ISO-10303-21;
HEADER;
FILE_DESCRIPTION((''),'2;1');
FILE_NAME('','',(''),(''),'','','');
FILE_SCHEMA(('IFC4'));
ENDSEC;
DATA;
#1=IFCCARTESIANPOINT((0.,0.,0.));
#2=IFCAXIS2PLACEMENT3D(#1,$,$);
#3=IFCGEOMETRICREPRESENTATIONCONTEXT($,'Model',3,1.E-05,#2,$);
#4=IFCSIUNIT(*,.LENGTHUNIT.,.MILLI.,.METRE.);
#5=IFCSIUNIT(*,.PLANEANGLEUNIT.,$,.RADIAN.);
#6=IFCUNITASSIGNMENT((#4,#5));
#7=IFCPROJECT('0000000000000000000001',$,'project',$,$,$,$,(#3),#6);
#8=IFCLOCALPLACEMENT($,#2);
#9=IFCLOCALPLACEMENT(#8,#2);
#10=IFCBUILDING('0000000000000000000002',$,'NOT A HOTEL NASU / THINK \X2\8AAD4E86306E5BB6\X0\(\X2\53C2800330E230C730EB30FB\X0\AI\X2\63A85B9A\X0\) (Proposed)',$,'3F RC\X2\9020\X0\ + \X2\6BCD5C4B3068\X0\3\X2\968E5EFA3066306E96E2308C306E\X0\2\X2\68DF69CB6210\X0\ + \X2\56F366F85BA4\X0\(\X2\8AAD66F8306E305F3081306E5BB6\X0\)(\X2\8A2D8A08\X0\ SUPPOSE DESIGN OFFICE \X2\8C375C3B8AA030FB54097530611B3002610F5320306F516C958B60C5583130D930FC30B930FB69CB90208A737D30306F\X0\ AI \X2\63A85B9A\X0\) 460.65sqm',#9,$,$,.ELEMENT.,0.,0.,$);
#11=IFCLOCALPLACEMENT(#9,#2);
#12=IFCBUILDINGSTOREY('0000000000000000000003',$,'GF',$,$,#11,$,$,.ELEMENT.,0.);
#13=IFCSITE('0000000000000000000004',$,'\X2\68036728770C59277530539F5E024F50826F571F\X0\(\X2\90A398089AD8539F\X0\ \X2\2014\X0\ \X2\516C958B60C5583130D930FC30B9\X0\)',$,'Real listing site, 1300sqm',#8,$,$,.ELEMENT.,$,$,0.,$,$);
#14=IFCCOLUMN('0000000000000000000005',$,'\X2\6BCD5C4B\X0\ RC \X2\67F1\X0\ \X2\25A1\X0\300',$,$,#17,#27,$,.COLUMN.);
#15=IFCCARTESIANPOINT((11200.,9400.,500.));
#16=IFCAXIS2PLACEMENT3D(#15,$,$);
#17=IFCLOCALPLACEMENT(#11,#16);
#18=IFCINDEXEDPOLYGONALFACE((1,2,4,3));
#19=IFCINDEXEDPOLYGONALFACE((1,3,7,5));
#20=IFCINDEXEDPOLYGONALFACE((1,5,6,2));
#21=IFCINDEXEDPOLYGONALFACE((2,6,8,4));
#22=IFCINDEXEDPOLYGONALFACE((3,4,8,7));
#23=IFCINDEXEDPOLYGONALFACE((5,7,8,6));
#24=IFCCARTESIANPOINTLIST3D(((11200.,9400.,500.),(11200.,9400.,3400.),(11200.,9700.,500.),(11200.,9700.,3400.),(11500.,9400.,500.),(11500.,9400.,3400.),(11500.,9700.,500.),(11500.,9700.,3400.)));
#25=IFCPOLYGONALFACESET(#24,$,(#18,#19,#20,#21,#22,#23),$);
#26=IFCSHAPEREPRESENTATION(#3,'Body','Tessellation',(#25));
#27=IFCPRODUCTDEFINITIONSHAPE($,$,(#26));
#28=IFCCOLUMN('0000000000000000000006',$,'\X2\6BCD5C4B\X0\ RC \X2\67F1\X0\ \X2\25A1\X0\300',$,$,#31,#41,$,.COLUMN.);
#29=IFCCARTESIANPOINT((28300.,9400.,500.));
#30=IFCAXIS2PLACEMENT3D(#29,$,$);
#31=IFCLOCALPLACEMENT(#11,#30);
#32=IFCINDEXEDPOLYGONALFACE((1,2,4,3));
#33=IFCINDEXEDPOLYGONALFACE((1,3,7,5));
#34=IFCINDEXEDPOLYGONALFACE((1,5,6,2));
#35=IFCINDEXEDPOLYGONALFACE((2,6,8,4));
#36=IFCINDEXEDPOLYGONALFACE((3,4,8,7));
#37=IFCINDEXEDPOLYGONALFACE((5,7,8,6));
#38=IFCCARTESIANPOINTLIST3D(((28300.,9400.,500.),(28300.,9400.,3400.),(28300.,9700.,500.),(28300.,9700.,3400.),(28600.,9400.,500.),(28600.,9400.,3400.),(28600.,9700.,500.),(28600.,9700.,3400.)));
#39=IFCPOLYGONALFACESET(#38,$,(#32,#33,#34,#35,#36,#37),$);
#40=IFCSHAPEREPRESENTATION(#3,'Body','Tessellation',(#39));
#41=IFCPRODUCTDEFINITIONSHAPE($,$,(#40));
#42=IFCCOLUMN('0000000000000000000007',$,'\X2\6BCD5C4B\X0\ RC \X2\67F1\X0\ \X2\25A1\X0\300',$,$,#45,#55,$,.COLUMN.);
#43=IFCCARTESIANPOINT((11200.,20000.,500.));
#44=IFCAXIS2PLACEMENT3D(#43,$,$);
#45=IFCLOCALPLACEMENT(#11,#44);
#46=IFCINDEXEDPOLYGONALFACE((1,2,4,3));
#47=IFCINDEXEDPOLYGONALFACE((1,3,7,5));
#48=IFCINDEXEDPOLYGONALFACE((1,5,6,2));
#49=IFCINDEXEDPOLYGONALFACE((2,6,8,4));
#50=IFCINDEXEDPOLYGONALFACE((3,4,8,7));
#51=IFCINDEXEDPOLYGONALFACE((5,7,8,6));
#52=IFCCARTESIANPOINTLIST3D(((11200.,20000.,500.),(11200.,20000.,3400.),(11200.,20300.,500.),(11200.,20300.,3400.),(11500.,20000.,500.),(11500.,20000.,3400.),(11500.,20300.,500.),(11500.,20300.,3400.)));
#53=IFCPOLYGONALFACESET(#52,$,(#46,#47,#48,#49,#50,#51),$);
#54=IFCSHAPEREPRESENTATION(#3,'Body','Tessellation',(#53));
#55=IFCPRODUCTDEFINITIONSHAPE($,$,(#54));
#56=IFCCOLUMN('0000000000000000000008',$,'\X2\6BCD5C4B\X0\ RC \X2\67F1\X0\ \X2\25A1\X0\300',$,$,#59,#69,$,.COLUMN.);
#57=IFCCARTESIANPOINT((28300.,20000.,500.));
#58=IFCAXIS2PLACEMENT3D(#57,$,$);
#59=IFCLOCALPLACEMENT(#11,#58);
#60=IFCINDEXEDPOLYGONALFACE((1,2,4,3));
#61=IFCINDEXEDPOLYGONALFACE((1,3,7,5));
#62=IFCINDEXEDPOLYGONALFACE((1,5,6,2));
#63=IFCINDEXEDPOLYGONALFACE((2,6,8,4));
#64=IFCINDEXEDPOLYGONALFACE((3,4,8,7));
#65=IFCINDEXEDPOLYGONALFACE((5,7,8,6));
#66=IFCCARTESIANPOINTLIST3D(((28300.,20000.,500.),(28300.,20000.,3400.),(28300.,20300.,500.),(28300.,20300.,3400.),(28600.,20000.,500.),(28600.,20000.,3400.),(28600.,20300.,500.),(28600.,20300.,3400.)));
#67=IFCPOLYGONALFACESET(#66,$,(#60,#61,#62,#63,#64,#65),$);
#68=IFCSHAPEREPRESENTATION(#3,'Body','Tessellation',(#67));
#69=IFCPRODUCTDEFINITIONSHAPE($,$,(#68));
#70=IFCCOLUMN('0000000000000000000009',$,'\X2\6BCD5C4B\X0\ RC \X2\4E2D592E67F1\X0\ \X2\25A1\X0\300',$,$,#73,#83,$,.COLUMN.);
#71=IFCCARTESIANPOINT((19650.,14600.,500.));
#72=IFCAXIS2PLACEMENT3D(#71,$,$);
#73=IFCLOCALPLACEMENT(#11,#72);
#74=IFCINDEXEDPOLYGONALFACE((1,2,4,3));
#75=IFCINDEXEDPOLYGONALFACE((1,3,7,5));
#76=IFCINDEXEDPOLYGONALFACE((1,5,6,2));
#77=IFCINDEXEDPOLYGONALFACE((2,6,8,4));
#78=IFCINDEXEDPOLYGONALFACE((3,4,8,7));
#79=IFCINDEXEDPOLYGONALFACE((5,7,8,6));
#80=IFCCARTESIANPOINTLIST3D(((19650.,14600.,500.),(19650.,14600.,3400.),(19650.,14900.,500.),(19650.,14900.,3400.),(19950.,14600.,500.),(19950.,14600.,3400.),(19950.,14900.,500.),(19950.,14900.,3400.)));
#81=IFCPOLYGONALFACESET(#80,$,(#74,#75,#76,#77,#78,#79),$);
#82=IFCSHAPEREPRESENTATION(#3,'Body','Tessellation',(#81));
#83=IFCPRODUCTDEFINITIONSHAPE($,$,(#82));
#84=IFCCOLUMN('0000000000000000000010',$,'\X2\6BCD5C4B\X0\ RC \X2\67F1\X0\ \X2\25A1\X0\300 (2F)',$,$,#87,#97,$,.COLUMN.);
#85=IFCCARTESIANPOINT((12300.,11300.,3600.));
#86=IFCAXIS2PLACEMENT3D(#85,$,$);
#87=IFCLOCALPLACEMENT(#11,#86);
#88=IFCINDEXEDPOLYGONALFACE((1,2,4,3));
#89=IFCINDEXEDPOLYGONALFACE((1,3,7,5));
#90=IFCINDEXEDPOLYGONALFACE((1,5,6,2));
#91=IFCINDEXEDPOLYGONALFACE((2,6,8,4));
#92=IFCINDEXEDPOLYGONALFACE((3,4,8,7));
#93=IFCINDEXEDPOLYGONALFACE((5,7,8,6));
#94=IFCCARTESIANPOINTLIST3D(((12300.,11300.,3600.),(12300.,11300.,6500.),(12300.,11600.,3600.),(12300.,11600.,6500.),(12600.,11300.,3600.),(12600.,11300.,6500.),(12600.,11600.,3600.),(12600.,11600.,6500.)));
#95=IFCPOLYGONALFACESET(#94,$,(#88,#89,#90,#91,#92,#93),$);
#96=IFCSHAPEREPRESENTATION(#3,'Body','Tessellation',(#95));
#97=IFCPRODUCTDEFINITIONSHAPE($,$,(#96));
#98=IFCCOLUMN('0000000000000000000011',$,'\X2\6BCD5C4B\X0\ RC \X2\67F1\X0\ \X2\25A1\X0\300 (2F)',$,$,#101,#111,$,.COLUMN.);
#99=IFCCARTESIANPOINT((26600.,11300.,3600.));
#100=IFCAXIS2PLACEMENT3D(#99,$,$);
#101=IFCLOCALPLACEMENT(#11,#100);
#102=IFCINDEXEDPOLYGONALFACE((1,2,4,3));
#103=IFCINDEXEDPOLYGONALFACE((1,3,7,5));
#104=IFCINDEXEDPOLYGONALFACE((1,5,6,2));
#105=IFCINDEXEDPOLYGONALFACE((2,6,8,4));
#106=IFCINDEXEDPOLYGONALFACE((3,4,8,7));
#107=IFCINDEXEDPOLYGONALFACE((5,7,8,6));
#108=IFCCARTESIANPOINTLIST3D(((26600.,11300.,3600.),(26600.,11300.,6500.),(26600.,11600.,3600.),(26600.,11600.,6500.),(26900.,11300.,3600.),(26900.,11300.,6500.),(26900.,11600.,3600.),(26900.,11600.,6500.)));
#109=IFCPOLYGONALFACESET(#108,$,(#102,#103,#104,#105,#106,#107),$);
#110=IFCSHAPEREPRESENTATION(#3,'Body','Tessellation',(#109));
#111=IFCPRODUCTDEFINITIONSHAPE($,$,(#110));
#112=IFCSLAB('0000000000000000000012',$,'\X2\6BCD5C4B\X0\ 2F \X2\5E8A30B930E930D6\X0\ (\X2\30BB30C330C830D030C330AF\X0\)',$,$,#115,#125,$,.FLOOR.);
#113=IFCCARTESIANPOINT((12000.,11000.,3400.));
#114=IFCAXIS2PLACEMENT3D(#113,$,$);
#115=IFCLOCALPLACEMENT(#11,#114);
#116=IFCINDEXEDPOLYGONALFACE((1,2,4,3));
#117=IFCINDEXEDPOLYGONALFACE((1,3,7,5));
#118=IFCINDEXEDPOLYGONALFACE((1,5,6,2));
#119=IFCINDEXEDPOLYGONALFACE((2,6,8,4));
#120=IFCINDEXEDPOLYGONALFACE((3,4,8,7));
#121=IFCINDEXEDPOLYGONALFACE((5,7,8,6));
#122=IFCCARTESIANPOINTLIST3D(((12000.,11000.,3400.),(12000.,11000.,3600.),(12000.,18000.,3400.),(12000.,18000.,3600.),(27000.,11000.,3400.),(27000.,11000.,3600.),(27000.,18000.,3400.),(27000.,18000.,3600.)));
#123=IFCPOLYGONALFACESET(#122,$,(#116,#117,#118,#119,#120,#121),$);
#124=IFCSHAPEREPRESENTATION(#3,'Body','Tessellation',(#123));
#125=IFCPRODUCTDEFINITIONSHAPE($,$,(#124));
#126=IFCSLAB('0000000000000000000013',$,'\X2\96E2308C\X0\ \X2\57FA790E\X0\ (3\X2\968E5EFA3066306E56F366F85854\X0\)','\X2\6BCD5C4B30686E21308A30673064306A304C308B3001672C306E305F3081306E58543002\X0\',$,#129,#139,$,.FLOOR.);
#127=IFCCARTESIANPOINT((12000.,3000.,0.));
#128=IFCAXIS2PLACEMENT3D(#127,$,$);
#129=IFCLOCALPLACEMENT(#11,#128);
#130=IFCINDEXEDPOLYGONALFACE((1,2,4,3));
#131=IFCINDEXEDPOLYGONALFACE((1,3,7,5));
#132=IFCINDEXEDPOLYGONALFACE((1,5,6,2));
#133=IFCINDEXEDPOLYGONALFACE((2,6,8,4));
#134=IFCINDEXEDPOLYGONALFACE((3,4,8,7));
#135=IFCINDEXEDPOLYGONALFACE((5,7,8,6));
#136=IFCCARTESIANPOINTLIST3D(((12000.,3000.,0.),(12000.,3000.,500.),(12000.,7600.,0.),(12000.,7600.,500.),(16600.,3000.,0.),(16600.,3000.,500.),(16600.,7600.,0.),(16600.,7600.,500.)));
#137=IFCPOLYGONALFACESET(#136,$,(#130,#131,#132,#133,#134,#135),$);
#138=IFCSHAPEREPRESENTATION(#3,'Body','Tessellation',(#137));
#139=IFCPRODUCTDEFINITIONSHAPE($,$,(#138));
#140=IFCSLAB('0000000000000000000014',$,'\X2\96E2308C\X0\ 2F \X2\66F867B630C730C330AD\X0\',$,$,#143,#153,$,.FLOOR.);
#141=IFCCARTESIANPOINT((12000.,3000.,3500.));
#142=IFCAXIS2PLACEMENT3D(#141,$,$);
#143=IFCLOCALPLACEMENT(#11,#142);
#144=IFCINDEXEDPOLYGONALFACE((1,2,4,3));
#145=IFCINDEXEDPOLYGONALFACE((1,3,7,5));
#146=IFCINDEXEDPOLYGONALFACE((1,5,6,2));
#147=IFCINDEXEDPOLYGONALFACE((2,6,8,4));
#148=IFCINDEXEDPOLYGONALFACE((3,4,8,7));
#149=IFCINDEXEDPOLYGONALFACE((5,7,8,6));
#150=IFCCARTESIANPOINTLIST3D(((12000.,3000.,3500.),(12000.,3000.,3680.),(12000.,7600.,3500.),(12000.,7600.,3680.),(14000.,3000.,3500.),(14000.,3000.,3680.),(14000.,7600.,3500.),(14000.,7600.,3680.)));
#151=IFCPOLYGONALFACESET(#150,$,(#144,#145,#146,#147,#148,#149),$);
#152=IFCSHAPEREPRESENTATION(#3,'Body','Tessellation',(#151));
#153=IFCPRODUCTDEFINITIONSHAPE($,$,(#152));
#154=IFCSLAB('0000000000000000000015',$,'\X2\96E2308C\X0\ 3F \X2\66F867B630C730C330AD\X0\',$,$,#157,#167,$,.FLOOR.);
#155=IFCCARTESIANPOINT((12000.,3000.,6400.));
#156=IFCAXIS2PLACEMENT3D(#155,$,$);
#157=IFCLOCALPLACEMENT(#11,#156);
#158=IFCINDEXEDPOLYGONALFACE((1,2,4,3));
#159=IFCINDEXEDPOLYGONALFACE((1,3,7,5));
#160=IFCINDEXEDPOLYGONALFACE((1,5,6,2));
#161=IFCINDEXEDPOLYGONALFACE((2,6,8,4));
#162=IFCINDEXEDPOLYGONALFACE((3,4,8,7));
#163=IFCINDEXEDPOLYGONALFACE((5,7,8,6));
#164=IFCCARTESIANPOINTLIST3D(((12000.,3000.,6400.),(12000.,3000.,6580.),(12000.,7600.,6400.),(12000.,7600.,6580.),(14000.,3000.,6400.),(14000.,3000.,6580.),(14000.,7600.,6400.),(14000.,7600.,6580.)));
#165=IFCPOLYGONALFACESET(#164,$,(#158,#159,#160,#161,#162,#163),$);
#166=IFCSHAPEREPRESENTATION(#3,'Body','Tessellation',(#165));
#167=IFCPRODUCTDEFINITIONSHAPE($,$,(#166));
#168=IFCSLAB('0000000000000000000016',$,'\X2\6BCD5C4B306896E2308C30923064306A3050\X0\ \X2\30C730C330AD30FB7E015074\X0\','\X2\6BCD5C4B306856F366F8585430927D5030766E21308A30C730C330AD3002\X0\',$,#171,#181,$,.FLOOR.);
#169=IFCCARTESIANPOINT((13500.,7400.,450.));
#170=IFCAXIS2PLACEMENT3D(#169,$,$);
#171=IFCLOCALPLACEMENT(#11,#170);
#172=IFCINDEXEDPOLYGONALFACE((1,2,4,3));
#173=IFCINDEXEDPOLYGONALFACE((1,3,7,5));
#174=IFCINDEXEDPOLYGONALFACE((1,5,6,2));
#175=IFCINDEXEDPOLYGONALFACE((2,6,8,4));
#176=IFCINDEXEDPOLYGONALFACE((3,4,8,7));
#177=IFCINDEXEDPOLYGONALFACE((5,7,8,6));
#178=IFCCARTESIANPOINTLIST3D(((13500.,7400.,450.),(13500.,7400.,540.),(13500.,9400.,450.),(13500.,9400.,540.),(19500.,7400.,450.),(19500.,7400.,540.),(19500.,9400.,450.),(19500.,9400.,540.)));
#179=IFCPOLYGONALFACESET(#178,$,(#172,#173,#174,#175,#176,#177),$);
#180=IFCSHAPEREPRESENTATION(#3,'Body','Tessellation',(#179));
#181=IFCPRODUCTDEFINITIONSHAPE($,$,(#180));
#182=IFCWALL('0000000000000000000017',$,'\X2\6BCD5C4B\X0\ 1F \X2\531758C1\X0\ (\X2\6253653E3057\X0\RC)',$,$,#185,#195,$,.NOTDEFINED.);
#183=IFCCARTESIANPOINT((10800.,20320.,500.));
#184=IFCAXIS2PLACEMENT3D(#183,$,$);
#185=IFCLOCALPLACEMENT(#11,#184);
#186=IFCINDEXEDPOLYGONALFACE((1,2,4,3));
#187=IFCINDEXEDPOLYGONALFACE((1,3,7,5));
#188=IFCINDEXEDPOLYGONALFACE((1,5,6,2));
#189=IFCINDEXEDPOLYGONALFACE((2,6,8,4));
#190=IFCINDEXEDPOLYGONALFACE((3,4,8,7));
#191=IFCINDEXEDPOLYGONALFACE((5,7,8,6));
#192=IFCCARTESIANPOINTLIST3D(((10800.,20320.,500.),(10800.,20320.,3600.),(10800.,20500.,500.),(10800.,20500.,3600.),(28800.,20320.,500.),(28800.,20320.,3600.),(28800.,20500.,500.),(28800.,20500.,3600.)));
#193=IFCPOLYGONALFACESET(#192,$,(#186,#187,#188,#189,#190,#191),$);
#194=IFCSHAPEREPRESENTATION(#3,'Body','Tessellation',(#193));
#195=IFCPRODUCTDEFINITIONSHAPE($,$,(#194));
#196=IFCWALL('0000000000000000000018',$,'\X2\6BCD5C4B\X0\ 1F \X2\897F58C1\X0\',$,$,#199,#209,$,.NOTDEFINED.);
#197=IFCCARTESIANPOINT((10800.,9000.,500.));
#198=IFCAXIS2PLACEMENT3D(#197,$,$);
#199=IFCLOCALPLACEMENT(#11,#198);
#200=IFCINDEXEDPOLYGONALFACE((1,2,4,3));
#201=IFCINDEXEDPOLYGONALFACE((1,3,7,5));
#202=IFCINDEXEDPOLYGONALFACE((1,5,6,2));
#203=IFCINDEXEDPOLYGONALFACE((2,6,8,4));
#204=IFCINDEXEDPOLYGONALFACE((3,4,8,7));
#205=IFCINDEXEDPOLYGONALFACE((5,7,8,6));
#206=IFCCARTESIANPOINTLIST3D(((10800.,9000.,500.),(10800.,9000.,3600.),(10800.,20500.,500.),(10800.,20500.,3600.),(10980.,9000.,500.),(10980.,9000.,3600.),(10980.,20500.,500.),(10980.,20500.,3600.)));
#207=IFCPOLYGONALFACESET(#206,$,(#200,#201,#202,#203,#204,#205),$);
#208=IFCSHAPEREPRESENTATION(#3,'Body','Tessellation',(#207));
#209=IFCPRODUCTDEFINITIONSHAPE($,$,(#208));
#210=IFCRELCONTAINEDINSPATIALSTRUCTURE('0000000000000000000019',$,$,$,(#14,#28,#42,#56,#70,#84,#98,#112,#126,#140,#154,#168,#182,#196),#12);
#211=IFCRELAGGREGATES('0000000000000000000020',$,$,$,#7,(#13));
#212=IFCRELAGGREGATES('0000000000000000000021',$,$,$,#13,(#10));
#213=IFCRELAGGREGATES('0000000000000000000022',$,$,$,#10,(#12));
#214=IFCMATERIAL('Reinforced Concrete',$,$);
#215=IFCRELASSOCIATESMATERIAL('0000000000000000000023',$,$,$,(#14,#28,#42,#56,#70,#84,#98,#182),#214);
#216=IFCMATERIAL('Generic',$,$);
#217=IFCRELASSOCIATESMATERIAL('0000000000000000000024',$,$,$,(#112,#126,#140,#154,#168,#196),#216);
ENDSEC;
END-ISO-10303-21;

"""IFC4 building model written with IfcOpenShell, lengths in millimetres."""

from ifc_helpers import new_model, si_unit, frame, frame_2d, origin, place, context, project, spatial, rectangle, extrude, material, element, save


model = new_model("IFC4")

# Units and contexts
model_context = context("Model", 3, precision=1e-05, world=origin())
ifc_project = project(units=[si_unit("LENGTHUNIT", "METRE", prefix="MILLI"), si_unit("PLANEANGLEUNIT", "RADIAN")], contexts=[model_context])

# Site, building, storey
site_placement = place(None, origin())
site = spatial("IfcSite", under=ifc_project, at=site_placement, Name="栃木県大田原市佐良土(那須高原 — 公開情報ベース)", ObjectType="Real listing site, 1300sqm", CompositionType="ELEMENT", RefElevation=0.0)
building_placement = place(site_placement, origin())
building = spatial("IfcBuilding", under=site, at=building_placement, Name="NOT A HOTEL NASU / THINK 読了の家(参考モデル・AI推定) (Proposed)", ObjectType="3F RC造 + 母屋と3階建ての離れの2棟構成 + 図書室(読書のための家)(設計 SUPPOSE DESIGN OFFICE 谷尻誠・吉田愛。意匠は公開情報ベース・構造詳細は AI 推定) 460.65sqm", CompositionType="ELEMENT", ElevationOfRefHeight=0.0, ElevationOfTerrain=0.0)
storey_placement = place(building_placement, origin())
storey = spatial("IfcBuildingStorey", under=building, at=storey_placement, Name="GF", CompositionType="ELEMENT", Elevation=0.0)

# Columns
ifc_material_1 = material(Name="Reinforced Concrete")
column_1_placement = place(storey_placement, frame((11200.0, 9400.0, 500.0)))
element("IfcColumn", 1, at=column_1_placement, inside=storey, material=ifc_material_1, Name="母屋 RC 柱 □300", PredefinedType="COLUMN", context=model_context, shape_type="SweptSolid", body=[
    extrude(rectangle(XDim=300.0, YDim=300.0, at=frame_2d((150.0, 150.0))), frame((11200.0, 9400.0, 500.0)), (0.0, 0.0, 1.0), 2900.0),
])
column_2_placement = place(storey_placement, frame((28300.0, 9400.0, 500.0)))
element("IfcColumn", 2, at=column_2_placement, inside=storey, material=ifc_material_1, Name="母屋 RC 柱 □300", PredefinedType="COLUMN", context=model_context, shape_type="SweptSolid", body=[
    extrude(rectangle(XDim=300.0, YDim=300.0, at=frame_2d((150.0, 150.0))), frame((28300.0, 9400.0, 500.0)), (0.0, 0.0, 1.0), 2900.0),
])
column_3_placement = place(storey_placement, frame((11200.0, 20000.0, 500.0)))
element("IfcColumn", 3, at=column_3_placement, inside=storey, material=ifc_material_1, Name="母屋 RC 柱 □300", PredefinedType="COLUMN", context=model_context, shape_type="SweptSolid", body=[
    extrude(rectangle(XDim=300.0, YDim=300.0, at=frame_2d((150.0, 150.0))), frame((11200.0, 20000.0, 500.0)), (0.0, 0.0, 1.0), 2900.0),
])
column_4_placement = place(storey_placement, frame((28300.0, 20000.0, 500.0)))
element("IfcColumn", 4, at=column_4_placement, inside=storey, material=ifc_material_1, Name="母屋 RC 柱 □300", PredefinedType="COLUMN", context=model_context, shape_type="SweptSolid", body=[
    extrude(rectangle(XDim=300.0, YDim=300.0, at=frame_2d((150.0, 150.0))), frame((28300.0, 20000.0, 500.0)), (0.0, 0.0, 1.0), 2900.0),
])
column_5_placement = place(storey_placement, frame((19650.0, 14600.0, 500.0)))
element("IfcColumn", 5, at=column_5_placement, inside=storey, material=ifc_material_1, Name="母屋 RC 中央柱 □300", PredefinedType="COLUMN", context=model_context, shape_type="SweptSolid", body=[
    extrude(rectangle(XDim=300.0, YDim=300.0, at=frame_2d((150.0, 150.0))), frame((19650.0, 14600.0, 500.0)), (0.0, 0.0, 1.0), 2900.0),
])
column_6_placement = place(storey_placement, frame((12300.0, 11300.0, 3600.0)))
element("IfcColumn", 6, at=column_6_placement, inside=storey, material=ifc_material_1, Name="母屋 RC 柱 □300 (2F)", PredefinedType="COLUMN", context=model_context, shape_type="SweptSolid", body=[
    extrude(rectangle(XDim=300.0, YDim=300.0, at=frame_2d((150.0, 150.0))), frame((12300.0, 11300.0, 3600.0)), (0.0, 0.0, 1.0), 2900.0),
])
column_7_placement = place(storey_placement, frame((26600.0, 11300.0, 3600.0)))
element("IfcColumn", 7, at=column_7_placement, inside=storey, material=ifc_material_1, Name="母屋 RC 柱 □300 (2F)", PredefinedType="COLUMN", context=model_context, shape_type="SweptSolid", body=[
    extrude(rectangle(XDim=300.0, YDim=300.0, at=frame_2d((150.0, 150.0))), frame((26600.0, 11300.0, 3600.0)), (0.0, 0.0, 1.0), 2900.0),
])

# Slabs
ifc_material_2 = material(Name="Generic")
slab_1_placement = place(storey_placement, frame((12000.0, 11000.0, 3400.0)))
element("IfcSlab", 8, at=slab_1_placement, inside=storey, material=ifc_material_2, Name="母屋 2F 床スラブ (セットバック)", PredefinedType="FLOOR", context=model_context, shape_type="SweptSolid", body=[
    extrude(rectangle(XDim=15000.0, YDim=7000.0, at=frame_2d((7500.0, 3500.0))), frame((12000.0, 11000.0, 3400.0)), (0.0, 0.0, 1.0), 200.0),
])
slab_2_placement = place(storey_placement, frame((12000.0, 3000.0, 0.0)))
element("IfcSlab", 9, at=slab_2_placement, inside=storey, material=ifc_material_2, Name="離れ 基礎 (3階建ての図書塔)", Description="母屋と渡りでつながる、本のための塔。", PredefinedType="FLOOR", context=model_context, shape_type="SweptSolid", body=[
    extrude(rectangle(XDim=4600.0, YDim=4600.0, at=frame_2d((2300.0, 2300.0))), frame((12000.0, 3000.0, 0.0)), (0.0, 0.0, 1.0), 500.0),
])
slab_3_placement = place(storey_placement, frame((12000.0, 3000.0, 3500.0)))
element("IfcSlab", 10, at=slab_3_placement, inside=storey, material=ifc_material_2, Name="離れ 2F 書架デッキ", PredefinedType="FLOOR", context=model_context, shape_type="SweptSolid", body=[
    extrude(rectangle(XDim=2000.0, YDim=4600.0, at=frame_2d((1000.0, 2300.0))), frame((12000.0, 3000.0, 3500.0)), (0.0, 0.0, 1.0), 180.0),
])
slab_4_placement = place(storey_placement, frame((12000.0, 3000.0, 6400.0)))
element("IfcSlab", 11, at=slab_4_placement, inside=storey, material=ifc_material_2, Name="離れ 3F 書架デッキ", PredefinedType="FLOOR", context=model_context, shape_type="SweptSolid", body=[
    extrude(rectangle(XDim=2000.0, YDim=4600.0, at=frame_2d((1000.0, 2300.0))), frame((12000.0, 3000.0, 6400.0)), (0.0, 0.0, 1.0), 180.0),
])
slab_5_placement = place(storey_placement, frame((13500.0, 7400.0, 450.0)))
element("IfcSlab", 12, at=slab_5_placement, inside=storey, material=ifc_material_2, Name="母屋と離れをつなぐ デッキ・縁側", Description="母屋と図書塔を結ぶ渡りデッキ。", PredefinedType="FLOOR", context=model_context, shape_type="SweptSolid", body=[
    extrude(rectangle(XDim=6000.0, YDim=2000.0, at=frame_2d((3000.0, 1000.0))), frame((13500.0, 7400.0, 450.0)), (0.0, 0.0, 1.0), 90.0),
])

# Walls
wall_1_placement = place(storey_placement, frame((10800.0, 20320.0, 500.0)))
element("IfcWall", 13, at=wall_1_placement, inside=storey, material=ifc_material_1, Name="母屋 1F 北壁 (打放しRC)", PredefinedType="NOTDEFINED", context=model_context, shape_type="SweptSolid", body=[
    extrude(rectangle(XDim=18000.0, YDim=180.0, at=frame_2d((9000.0, 90.0))), frame((10800.0, 20320.0, 500.0)), (0.0, 0.0, 1.0), 3100.0),
])
wall_2_placement = place(storey_placement, frame((10800.0, 9000.0, 500.0)))
element("IfcWall", 14, at=wall_2_placement, inside=storey, material=ifc_material_2, Name="母屋 1F 西壁", PredefinedType="NOTDEFINED", context=model_context, shape_type="SweptSolid", body=[
    extrude(rectangle(XDim=180.0, YDim=11500.0, at=frame_2d((90.0, 5750.0))), frame((10800.0, 9000.0, 500.0)), (0.0, 0.0, 1.0), 3100.0),
])

save(model, "model.ifc")
